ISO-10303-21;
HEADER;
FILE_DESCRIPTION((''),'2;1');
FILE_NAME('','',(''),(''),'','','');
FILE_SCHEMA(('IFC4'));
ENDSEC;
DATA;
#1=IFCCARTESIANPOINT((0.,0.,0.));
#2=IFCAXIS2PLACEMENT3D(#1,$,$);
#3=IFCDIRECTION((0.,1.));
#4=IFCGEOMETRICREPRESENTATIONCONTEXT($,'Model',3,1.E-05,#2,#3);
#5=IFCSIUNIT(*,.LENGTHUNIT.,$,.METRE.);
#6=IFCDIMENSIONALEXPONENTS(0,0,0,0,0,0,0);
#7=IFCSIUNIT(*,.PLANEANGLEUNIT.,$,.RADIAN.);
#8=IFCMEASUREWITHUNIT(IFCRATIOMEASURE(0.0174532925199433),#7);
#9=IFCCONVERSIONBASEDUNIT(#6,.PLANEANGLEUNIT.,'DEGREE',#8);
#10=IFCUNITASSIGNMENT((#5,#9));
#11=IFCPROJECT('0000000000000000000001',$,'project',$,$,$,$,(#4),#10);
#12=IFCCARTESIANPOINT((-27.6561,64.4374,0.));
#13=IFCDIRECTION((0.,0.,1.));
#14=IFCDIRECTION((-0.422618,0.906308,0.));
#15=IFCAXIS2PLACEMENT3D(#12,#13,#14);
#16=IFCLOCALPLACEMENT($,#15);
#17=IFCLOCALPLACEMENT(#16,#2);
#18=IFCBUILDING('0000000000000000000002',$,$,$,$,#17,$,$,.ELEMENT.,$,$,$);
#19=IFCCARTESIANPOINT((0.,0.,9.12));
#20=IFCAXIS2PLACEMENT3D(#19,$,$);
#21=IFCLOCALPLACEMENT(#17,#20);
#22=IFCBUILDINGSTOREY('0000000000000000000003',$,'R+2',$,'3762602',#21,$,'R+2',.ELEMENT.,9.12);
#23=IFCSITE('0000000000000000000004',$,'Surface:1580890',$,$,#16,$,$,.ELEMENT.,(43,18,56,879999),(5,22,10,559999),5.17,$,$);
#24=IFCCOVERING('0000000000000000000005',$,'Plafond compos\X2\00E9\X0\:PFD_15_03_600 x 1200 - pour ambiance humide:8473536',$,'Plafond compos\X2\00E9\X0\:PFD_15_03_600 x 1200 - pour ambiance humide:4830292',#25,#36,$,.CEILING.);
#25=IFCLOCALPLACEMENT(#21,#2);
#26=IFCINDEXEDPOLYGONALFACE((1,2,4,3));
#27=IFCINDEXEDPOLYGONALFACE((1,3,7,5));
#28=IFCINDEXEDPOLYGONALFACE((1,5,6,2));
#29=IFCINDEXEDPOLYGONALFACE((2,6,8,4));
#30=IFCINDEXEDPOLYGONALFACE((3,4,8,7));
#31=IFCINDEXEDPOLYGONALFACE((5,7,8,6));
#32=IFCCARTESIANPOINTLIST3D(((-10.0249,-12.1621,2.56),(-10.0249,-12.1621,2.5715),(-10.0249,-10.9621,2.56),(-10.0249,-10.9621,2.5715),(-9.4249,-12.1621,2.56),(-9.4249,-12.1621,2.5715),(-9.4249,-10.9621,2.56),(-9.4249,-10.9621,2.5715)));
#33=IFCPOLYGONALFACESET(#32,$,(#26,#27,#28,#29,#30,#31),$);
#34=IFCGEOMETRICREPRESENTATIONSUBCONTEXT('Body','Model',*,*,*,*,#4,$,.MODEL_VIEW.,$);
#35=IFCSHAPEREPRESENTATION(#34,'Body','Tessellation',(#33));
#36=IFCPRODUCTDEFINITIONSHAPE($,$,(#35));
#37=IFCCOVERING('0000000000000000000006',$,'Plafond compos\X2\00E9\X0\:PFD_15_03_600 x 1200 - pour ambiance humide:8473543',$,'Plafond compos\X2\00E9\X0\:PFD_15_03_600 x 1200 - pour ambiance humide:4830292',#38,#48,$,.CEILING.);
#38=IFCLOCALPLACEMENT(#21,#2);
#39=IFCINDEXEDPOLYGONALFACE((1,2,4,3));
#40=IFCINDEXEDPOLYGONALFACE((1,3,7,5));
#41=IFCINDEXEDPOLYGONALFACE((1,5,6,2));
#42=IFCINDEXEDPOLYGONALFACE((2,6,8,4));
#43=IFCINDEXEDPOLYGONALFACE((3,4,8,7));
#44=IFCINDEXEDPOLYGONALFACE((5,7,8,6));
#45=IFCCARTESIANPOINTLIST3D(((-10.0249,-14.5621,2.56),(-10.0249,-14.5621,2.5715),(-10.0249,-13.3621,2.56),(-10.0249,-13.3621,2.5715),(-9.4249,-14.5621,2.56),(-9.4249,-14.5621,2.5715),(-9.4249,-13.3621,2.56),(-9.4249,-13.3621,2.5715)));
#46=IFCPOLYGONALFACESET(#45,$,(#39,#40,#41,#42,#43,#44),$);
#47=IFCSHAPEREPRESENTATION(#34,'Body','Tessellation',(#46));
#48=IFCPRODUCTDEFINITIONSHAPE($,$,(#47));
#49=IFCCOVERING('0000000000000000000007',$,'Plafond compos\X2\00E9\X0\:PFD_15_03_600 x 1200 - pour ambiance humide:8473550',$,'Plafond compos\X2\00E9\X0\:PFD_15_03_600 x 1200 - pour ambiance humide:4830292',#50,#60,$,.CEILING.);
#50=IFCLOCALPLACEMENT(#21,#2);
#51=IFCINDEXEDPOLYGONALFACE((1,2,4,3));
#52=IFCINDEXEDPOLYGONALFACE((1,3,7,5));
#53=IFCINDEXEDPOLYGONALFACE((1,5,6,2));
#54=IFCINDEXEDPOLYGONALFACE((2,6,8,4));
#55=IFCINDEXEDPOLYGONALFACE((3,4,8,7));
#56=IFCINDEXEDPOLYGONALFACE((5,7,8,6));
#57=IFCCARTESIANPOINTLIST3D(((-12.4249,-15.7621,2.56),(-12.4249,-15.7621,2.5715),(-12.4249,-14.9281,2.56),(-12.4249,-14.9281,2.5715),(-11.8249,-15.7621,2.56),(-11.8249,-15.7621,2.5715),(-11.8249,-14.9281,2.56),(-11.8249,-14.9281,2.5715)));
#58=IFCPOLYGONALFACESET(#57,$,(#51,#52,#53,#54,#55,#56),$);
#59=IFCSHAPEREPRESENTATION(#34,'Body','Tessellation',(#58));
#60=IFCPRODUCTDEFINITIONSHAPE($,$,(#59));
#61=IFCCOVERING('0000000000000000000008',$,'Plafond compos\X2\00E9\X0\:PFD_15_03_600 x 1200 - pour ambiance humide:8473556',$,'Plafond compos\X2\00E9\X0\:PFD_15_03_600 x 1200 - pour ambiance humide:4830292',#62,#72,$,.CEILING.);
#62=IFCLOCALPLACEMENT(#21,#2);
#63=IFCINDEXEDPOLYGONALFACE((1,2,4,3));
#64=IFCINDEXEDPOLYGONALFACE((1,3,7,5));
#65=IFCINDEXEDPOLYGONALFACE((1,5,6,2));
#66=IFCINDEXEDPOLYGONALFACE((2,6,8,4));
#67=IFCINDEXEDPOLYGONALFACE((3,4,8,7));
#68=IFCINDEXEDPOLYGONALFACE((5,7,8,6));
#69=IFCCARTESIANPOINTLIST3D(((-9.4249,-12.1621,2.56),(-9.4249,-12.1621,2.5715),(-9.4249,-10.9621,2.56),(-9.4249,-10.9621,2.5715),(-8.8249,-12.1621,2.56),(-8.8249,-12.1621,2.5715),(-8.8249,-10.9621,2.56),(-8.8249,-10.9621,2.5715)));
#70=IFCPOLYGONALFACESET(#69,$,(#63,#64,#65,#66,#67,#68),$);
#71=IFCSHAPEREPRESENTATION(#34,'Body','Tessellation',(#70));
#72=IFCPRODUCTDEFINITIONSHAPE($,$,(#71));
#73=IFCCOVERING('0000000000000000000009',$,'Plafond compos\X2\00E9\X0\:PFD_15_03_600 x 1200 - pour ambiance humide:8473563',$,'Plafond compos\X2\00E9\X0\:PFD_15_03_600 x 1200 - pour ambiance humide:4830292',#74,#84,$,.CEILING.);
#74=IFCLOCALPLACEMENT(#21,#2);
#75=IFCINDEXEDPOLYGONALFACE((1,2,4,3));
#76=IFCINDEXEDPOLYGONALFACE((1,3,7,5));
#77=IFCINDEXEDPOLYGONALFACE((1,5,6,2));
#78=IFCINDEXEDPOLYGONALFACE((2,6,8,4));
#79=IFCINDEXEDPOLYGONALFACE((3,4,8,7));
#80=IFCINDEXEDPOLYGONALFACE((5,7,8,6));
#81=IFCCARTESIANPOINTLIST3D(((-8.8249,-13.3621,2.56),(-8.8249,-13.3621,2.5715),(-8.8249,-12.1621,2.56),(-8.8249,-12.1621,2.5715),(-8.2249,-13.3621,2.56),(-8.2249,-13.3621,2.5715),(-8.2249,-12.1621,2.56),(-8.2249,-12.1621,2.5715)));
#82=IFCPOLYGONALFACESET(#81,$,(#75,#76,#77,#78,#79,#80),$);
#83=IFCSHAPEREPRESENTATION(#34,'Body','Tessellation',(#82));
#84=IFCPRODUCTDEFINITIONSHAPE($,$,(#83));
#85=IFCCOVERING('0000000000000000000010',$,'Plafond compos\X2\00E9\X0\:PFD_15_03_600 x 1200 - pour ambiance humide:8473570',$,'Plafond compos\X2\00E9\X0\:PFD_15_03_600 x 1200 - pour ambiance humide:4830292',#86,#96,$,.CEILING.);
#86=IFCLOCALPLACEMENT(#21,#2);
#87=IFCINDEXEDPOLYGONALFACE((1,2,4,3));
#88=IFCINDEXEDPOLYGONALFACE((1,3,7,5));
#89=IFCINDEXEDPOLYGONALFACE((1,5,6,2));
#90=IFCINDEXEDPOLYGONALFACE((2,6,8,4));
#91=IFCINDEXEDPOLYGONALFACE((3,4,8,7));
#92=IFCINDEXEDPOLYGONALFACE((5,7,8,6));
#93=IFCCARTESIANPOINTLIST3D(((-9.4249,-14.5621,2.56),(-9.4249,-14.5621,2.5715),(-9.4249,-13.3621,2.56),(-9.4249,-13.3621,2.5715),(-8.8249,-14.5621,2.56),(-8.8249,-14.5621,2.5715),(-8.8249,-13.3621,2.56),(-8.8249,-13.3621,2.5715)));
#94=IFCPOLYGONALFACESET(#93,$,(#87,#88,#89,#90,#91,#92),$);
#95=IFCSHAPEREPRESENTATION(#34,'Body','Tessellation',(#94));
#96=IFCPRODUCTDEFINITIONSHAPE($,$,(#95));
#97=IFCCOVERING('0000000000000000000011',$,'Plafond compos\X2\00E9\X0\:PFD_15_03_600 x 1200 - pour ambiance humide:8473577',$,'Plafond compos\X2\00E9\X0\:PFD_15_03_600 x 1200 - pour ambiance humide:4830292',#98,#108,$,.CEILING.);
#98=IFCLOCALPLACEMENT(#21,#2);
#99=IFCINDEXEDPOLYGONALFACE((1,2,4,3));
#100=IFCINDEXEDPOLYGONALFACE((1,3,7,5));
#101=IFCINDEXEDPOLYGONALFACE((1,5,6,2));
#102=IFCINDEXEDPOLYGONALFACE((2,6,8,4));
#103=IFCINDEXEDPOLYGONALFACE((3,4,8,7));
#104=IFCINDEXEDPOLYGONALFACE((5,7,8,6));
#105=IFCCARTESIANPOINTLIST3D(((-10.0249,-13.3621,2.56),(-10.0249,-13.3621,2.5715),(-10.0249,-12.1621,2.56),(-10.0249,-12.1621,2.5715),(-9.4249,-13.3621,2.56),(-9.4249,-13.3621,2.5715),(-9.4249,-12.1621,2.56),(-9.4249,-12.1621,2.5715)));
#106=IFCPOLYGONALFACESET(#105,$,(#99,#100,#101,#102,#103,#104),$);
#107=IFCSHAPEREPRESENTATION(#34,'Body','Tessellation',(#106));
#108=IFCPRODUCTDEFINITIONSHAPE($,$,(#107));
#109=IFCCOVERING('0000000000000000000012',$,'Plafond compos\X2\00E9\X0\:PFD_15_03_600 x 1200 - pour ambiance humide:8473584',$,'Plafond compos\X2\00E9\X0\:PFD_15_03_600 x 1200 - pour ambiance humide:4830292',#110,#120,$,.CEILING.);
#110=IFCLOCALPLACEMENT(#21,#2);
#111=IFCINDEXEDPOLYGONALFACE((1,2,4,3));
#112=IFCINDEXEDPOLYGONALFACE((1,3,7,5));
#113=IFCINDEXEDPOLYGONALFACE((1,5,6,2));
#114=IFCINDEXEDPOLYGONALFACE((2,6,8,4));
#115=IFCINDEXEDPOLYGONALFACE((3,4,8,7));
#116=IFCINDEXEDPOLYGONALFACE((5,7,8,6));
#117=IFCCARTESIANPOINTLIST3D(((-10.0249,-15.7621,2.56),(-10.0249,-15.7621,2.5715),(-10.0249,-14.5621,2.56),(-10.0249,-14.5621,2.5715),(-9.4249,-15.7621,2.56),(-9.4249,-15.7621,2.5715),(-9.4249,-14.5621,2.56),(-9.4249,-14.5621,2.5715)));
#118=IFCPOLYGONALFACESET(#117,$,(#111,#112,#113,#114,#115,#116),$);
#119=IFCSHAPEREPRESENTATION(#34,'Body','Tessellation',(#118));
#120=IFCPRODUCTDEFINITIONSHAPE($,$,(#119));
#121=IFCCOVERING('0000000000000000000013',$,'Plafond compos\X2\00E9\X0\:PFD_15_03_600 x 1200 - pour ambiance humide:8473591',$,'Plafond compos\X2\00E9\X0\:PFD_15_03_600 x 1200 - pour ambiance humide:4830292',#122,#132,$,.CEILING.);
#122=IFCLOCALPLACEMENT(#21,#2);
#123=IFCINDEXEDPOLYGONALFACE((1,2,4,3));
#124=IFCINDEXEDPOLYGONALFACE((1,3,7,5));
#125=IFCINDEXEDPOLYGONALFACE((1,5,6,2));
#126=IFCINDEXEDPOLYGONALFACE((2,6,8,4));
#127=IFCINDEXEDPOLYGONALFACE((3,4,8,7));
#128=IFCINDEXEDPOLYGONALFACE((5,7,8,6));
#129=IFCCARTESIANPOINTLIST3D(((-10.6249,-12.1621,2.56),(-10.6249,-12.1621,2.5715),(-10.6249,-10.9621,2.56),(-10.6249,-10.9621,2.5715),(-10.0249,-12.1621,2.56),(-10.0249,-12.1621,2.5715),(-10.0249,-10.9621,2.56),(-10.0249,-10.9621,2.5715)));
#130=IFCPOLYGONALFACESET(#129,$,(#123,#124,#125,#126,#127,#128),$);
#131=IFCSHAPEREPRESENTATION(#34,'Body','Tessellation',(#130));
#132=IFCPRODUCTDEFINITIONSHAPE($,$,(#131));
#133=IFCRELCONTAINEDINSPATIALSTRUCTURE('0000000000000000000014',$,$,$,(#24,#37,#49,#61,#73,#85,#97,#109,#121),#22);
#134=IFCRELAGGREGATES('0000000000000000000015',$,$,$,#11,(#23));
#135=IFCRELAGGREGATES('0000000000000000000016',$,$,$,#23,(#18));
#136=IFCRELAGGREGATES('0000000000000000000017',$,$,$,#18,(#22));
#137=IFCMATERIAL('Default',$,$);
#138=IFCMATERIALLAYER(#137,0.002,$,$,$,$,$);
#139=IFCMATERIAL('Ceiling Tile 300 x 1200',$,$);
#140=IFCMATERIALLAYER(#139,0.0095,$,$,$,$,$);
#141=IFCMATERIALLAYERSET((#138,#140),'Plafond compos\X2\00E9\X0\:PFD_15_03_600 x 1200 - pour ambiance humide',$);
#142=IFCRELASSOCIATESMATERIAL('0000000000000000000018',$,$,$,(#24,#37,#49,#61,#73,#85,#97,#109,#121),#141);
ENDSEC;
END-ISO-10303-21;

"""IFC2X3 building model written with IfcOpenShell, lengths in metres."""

from ifc_helpers import new_model, entity, si_unit, converted_unit, direction, frame, frame_2d, origin, origin_2d_with_axis, place, context, subcontext, project, spatial, rectangle, extrude, material, layer, layer_set, layer_usage, element, save


model = new_model("IFC2X3")

# Units and contexts
model_context = context("Model", 3, precision=1e-05, world=origin(), true_north=direction((0.0, 1.0)))
body_context = subcontext(model_context, "Body", "Model", "MODEL_VIEW")
ifc_project = project(units=[si_unit("LENGTHUNIT", "METRE"), converted_unit("PLANEANGLEUNIT", "DEGREE", entity("IfcRatioMeasure", 0.0174532925199433), si_unit("PLANEANGLEUNIT", "RADIAN"), dimensions=[0, 0, 0, 0, 0, 0, 0])], contexts=[model_context])

# Site, building, storey
site_placement = place(None, frame((-27.6561, 64.4374, 0.0), z_axis=(0.0, 0.0, 1.0), x_axis=(-0.422618, 0.906308, 0.0)))
site = spatial("IfcSite", under=ifc_project, at=site_placement, Name="Surface:1580890", CompositionType="ELEMENT", RefLatitude=(43, 18, 56, 879999), RefLongitude=(5, 22, 10, 559999), RefElevation=5.17)
building_placement = place(site_placement, origin())
building = spatial("IfcBuilding", under=site, at=building_placement, CompositionType="ELEMENT")
storey_placement = place(building_placement, frame((0.0, 0.0, 9.12)))
storey = spatial("IfcBuildingStorey", under=building, at=storey_placement, Name="R+2", ObjectType="3762602", LongName="R+2", CompositionType="ELEMENT", Elevation=9.12)

# Coverings
ifc_material_1 = material(Name="Default")
ifc_layer_1 = layer(ifc_material_1, 0.002)
ifc_material_2 = material(Name="Ceiling Tile 300 x 1200")
ifc_layer_2 = layer(ifc_material_2, 0.0095)
ifc_layer_set = layer_set([ifc_layer_1, ifc_layer_2], Name="Plafond composé:PFD_15_03_600 x 1200 - pour ambiance humide")
ifc_layer_usage_1 = layer_usage(ifc_layer_set, "AXIS3", "POSITIVE", 0.0)
covering_1_placement = place(storey_placement, origin())
element("IfcCovering", 1, at=covering_1_placement, inside=storey, material=ifc_layer_usage_1, Name="Plafond composé:PFD_15_03_600 x 1200 - pour ambiance humide:8473536", ObjectType="Plafond composé:PFD_15_03_600 x 1200 - pour ambiance humide:4830292", PredefinedType="CEILING", context=body_context, shape_type="SweptSolid", body=[
    extrude(rectangle(XDim=0.6, YDim=1.2, at=frame_2d((0.0, 0.0), x_axis=(1.0, 0.0))), frame((-9.7249, -11.5621, 2.56), z_axis=(0.0, 0.0, 1.0), x_axis=(-1.0, 0.0, 0.0)), (0.0, 0.0, 1.0), 0.0115),
])
ifc_layer_usage_2 = layer_usage(ifc_layer_set, "AXIS3", "POSITIVE", 0.0)
covering_2_placement = place(storey_placement, origin())
element("IfcCovering", 2, at=covering_2_placement, inside=storey, material=ifc_layer_usage_2, Name="Plafond composé:PFD_15_03_600 x 1200 - pour ambiance humide:8473543", ObjectType="Plafond composé:PFD_15_03_600 x 1200 - pour ambiance humide:4830292", PredefinedType="CEILING", context=body_context, shape_type="SweptSolid", body=[
    extrude(rectangle(XDim=0.6, YDim=1.2, at=frame_2d((0.0, 0.0), x_axis=(1.0, 0.0))), frame((-9.7249, -13.9621, 2.56), z_axis=(0.0, 0.0, 1.0), x_axis=(-1.0, 0.0, 0.0)), (0.0, 0.0, 1.0), 0.0115),
])
ifc_layer_usage_3 = layer_usage(ifc_layer_set, "AXIS3", "POSITIVE", 0.0)
covering_3_placement = place(storey_placement, origin())
element("IfcCovering", 3, at=covering_3_placement, inside=storey, material=ifc_layer_usage_3, Name="Plafond composé:PFD_15_03_600 x 1200 - pour ambiance humide:8473550", ObjectType="Plafond composé:PFD_15_03_600 x 1200 - pour ambiance humide:4830292", PredefinedType="CEILING", context=body_context, shape_type="SweptSolid", body=[
    extrude(rectangle(XDim=0.6, YDim=0.834, at=origin_2d_with_axis()), frame((-12.1249, -15.3451, 2.56), z_axis=(0.0, 0.0, 1.0), x_axis=(-1.0, 0.0, 0.0)), (0.0, 0.0, 1.0), 0.0115),
])
ifc_layer_usage_4 = layer_usage(ifc_layer_set, "AXIS3", "POSITIVE", 0.0)
covering_4_placement = place(storey_placement, origin())
element("IfcCovering", 4, at=covering_4_placement, inside=storey, material=ifc_layer_usage_4, Name="Plafond composé:PFD_15_03_600 x 1200 - pour ambiance humide:8473556", ObjectType="Plafond composé:PFD_15_03_600 x 1200 - pour ambiance humide:4830292", PredefinedType="CEILING", context=body_context, shape_type="SweptSolid", body=[
    extrude(rectangle(XDim=0.6, YDim=1.2, at=origin_2d_with_axis()), frame((-9.1249, -11.5621, 2.56), z_axis=(0.0, 0.0, 1.0), x_axis=(-1.0, 0.0, 0.0)), (0.0, 0.0, 1.0), 0.0115),
])
ifc_layer_usage_5 = layer_usage(ifc_layer_set, "AXIS3", "POSITIVE", 0.0)
covering_5_placement = place(storey_placement, origin())
element("IfcCovering", 5, at=covering_5_placement, inside=storey, material=ifc_layer_usage_5, Name="Plafond composé:PFD_15_03_600 x 1200 - pour ambiance humide:8473563", ObjectType="Plafond composé:PFD_15_03_600 x 1200 - pour ambiance humide:4830292", PredefinedType="CEILING", context=body_context, shape_type="SweptSolid", body=[
    extrude(rectangle(XDim=0.6, YDim=1.2, at=frame_2d((0.0, 0.0), x_axis=(1.0, 0.0))), frame((-8.5249, -12.7621, 2.56), z_axis=(0.0, 0.0, 1.0), x_axis=(-1.0, 0.0, 0.0)), (0.0, 0.0, 1.0), 0.0115),
])
ifc_layer_usage_6 = layer_usage(ifc_layer_set, "AXIS3", "POSITIVE", 0.0)
covering_6_placement = place(storey_placement, origin())
element("IfcCovering", 6, at=covering_6_placement, inside=storey, material=ifc_layer_usage_6, Name="Plafond composé:PFD_15_03_600 x 1200 - pour ambiance humide:8473570", ObjectType="Plafond composé:PFD_15_03_600 x 1200 - pour ambiance humide:4830292", PredefinedType="CEILING", context=body_context, shape_type="SweptSolid", body=[
    extrude(rectangle(XDim=0.6, YDim=1.2, at=origin_2d_with_axis()), frame((-9.1249, -13.9621, 2.56), z_axis=(0.0, 0.0, 1.0), x_axis=(-1.0, 0.0, 0.0)), (0.0, 0.0, 1.0), 0.0115),
])
ifc_layer_usage_7 = layer_usage(ifc_layer_set, "AXIS3", "POSITIVE", 0.0)
covering_7_placement = place(storey_placement, origin())
element("IfcCovering", 7, at=covering_7_placement, inside=storey, material=ifc_layer_usage_7, Name="Plafond composé:PFD_15_03_600 x 1200 - pour ambiance humide:8473577", ObjectType="Plafond composé:PFD_15_03_600 x 1200 - pour ambiance humide:4830292", PredefinedType="CEILING", context=body_context, shape_type="SweptSolid", body=[
    extrude(rectangle(XDim=0.6, YDim=1.2, at=origin_2d_with_axis()), frame((-9.7249, -12.7621, 2.56), z_axis=(0.0, 0.0, 1.0), x_axis=(-1.0, 0.0, 0.0)), (0.0, 0.0, 1.0), 0.0115),
])
ifc_layer_usage_8 = layer_usage(ifc_layer_set, "AXIS3", "POSITIVE", 0.0)
covering_8_placement = place(storey_placement, origin())
element("IfcCovering", 8, at=covering_8_placement, inside=storey, material=ifc_layer_usage_8, Name="Plafond composé:PFD_15_03_600 x 1200 - pour ambiance humide:8473584", ObjectType="Plafond composé:PFD_15_03_600 x 1200 - pour ambiance humide:4830292", PredefinedType="CEILING", context=body_context, shape_type="SweptSolid", body=[
    extrude(rectangle(XDim=0.6, YDim=1.2, at=frame_2d((0.0, 0.0), x_axis=(1.0, 0.0))), frame((-9.7249, -15.1621, 2.56), z_axis=(0.0, 0.0, 1.0), x_axis=(-1.0, 0.0, 0.0)), (0.0, 0.0, 1.0), 0.0115),
])
ifc_layer_usage_9 = layer_usage(ifc_layer_set, "AXIS3", "POSITIVE", 0.0)
covering_9_placement = place(storey_placement, origin())
element("IfcCovering", 9, at=covering_9_placement, inside=storey, material=ifc_layer_usage_9, Name="Plafond composé:PFD_15_03_600 x 1200 - pour ambiance humide:8473591", ObjectType="Plafond composé:PFD_15_03_600 x 1200 - pour ambiance humide:4830292", PredefinedType="CEILING", context=body_context, shape_type="SweptSolid", body=[
    extrude(rectangle(XDim=0.6, YDim=1.2, at=origin_2d_with_axis()), frame((-10.3249, -11.5621, 2.56), z_axis=(0.0, 0.0, 1.0), x_axis=(-1.0, 0.0, 0.0)), (0.0, 0.0, 1.0), 0.0115),
])

save(model, "model.ifc")
